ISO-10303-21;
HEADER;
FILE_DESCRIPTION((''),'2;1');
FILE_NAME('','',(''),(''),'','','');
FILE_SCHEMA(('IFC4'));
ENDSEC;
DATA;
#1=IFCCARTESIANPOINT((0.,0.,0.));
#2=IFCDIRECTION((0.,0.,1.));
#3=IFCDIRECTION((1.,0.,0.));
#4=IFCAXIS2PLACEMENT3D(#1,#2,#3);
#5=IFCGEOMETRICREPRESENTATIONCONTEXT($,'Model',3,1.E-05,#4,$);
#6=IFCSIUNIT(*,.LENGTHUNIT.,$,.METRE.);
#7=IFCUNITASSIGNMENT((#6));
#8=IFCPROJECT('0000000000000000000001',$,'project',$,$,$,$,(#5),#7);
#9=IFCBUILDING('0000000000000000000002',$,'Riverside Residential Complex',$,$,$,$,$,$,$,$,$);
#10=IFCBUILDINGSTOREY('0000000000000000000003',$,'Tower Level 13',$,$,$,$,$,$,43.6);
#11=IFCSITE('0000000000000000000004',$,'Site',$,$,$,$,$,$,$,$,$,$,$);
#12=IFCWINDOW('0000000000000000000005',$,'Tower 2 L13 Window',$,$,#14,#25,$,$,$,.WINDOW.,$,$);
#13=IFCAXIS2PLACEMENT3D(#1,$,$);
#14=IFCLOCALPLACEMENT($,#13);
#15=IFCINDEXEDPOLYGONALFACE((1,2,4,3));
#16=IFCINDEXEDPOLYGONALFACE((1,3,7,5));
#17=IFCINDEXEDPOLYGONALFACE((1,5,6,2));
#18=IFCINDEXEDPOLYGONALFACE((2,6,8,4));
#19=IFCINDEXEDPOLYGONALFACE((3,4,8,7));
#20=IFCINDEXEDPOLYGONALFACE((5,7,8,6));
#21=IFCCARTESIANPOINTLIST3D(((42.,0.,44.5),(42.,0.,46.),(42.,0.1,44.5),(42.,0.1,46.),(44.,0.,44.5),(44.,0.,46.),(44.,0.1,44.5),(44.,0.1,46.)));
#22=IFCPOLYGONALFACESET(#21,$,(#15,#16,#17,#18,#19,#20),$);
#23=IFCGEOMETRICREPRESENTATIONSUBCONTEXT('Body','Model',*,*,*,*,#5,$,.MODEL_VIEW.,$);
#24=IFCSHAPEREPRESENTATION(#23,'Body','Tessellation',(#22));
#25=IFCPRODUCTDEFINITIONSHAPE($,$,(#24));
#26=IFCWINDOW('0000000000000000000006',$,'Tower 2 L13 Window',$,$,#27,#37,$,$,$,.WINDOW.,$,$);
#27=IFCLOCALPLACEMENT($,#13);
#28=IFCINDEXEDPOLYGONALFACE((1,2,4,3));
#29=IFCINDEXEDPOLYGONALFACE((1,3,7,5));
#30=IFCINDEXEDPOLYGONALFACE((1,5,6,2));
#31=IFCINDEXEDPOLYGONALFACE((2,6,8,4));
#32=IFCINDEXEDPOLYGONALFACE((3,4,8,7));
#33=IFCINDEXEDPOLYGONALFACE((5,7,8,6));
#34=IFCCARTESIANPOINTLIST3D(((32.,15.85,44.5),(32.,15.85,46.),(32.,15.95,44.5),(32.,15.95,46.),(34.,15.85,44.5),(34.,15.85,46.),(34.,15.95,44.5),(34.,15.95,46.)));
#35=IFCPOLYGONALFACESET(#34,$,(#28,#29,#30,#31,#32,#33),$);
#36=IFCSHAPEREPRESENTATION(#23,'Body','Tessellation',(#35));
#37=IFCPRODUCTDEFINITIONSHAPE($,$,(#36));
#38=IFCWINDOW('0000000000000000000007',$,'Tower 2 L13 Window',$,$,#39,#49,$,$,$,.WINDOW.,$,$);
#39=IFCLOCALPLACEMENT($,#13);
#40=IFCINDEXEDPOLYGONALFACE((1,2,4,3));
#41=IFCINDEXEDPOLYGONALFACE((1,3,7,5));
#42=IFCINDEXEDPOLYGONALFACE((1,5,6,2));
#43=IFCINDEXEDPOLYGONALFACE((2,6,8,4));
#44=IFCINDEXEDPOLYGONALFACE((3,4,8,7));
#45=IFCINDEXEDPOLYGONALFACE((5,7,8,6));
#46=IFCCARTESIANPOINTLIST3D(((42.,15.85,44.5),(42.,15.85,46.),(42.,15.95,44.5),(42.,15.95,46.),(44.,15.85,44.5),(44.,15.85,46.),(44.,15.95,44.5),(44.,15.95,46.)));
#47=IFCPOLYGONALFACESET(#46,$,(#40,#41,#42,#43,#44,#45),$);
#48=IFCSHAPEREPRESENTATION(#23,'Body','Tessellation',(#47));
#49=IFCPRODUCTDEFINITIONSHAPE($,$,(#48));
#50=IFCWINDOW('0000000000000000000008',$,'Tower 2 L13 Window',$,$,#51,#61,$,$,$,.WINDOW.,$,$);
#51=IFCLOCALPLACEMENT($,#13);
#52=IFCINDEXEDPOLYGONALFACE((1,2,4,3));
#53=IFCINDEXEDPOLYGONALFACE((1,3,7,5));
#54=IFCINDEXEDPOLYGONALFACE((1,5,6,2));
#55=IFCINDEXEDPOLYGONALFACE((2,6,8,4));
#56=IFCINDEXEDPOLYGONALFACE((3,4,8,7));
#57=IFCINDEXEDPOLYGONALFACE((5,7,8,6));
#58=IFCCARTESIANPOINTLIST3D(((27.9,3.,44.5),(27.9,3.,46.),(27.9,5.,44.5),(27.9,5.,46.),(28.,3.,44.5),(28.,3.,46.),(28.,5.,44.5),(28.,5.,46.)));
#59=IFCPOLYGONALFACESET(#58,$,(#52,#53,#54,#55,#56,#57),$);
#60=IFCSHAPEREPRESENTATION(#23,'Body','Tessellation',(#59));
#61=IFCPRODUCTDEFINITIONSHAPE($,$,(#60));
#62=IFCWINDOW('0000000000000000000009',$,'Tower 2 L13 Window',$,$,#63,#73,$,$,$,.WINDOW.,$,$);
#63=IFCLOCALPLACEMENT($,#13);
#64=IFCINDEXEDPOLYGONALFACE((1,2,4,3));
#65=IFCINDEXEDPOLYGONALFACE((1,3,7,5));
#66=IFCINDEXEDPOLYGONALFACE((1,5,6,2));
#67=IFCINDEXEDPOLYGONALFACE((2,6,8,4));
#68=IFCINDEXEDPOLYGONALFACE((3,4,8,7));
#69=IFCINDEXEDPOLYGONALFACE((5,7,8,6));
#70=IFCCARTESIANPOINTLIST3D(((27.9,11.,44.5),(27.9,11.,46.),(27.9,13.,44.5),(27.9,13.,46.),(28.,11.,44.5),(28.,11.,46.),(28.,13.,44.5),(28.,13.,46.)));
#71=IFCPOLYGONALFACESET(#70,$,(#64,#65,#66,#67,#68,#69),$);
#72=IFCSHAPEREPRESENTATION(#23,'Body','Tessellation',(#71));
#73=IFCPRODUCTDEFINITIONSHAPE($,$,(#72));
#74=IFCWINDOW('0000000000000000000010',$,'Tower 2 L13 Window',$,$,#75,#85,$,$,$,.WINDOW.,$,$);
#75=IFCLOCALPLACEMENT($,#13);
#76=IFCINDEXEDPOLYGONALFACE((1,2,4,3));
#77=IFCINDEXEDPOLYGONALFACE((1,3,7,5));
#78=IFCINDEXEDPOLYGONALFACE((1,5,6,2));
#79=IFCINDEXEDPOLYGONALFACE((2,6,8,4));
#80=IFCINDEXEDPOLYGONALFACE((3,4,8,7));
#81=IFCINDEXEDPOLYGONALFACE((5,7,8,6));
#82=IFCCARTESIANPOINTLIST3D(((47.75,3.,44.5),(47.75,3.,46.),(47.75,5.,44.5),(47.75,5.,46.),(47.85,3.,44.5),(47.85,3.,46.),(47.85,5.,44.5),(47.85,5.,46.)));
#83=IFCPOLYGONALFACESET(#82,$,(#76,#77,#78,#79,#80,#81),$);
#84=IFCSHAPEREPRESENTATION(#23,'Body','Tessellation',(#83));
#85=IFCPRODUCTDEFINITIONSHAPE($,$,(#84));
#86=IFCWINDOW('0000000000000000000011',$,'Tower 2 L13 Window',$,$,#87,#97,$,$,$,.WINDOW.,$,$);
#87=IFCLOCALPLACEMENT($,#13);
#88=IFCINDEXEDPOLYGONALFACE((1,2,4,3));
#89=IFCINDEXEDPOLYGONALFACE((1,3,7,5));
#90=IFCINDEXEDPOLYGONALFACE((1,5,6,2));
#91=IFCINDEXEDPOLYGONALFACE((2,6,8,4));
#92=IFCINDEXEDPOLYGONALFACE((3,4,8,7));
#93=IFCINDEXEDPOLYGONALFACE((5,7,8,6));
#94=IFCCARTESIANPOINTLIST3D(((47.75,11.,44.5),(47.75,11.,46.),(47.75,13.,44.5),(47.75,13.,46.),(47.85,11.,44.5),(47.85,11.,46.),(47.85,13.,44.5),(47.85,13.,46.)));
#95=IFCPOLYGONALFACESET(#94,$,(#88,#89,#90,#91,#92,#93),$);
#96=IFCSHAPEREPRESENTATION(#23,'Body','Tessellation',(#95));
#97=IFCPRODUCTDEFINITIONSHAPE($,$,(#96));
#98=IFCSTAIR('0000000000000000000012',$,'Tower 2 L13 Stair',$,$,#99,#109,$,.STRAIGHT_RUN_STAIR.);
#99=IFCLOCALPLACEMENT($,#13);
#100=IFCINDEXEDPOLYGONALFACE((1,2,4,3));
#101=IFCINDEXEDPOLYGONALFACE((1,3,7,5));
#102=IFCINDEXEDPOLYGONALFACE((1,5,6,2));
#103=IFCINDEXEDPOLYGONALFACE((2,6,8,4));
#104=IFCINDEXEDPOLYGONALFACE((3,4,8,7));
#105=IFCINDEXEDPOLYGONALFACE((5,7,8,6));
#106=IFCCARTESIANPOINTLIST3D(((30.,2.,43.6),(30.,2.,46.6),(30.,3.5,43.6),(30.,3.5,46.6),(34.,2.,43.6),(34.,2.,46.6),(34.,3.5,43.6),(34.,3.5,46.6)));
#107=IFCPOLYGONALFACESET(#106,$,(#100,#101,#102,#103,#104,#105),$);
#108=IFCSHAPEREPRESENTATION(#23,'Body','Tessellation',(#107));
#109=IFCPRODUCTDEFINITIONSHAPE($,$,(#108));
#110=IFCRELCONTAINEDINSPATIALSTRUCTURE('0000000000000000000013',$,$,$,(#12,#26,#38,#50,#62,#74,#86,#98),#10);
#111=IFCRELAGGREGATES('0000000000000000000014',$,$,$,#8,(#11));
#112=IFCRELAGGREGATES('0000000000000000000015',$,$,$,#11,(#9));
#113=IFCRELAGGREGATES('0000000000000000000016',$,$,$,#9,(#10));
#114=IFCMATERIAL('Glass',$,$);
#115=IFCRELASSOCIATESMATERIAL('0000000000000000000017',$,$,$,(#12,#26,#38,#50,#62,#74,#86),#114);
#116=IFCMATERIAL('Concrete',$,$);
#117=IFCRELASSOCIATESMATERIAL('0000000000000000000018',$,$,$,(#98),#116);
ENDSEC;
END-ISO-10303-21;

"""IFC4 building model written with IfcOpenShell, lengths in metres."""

from ifc_helpers import new_model, si_unit, frame, origin_with_axes, place, context, subcontext, project, spatial, line, indexed_curve, outline, extrude, material, element, save


model = new_model("IFC4")

# Units and contexts
model_context = context("Model", 3, precision=1e-05, world=origin_with_axes())
body_context = subcontext(model_context, "Body", "Model", "MODEL_VIEW")
ifc_project = project(units=[si_unit("LENGTHUNIT", "METRE")], contexts=[model_context])

# Site, building, storey
site = spatial("IfcSite", under=ifc_project, Name="Site")
building = spatial("IfcBuilding", under=site, Name="Riverside Residential Complex")
storey = spatial("IfcBuildingStorey", under=building, Name="Tower Level 13", Elevation=43.6)

# Shared definitions
ifc_material_1 = material(Name="Concrete")

# Windows
ifc_material_2 = material(Name="Glass")
for number, where, z_axis, x_axis, name in (
    (1, (42.0, 0.0, 44.5), (0.0, 0.0, 1.0), (1.0, 0.0, 0.0), "Tower 2 L13 Window"),
    (2, (32.0, 15.85, 44.5), (0.0, 0.0, 1.0), (1.0, 0.0, 0.0), "Tower 2 L13 Window"),
    (3, (42.0, 15.85, 44.5), (0.0, 0.0, 1.0), (1.0, 0.0, 0.0), "Tower 2 L13 Window"),
    (4, (28.0, 3.0, 44.5), (0.0, 0.0, 1.0), (0.0, 1.0, 0.0), "Tower 2 L13 Window"),
    (5, (28.0, 11.0, 44.5), (0.0, 0.0, 1.0), (0.0, 1.0, 0.0), "Tower 2 L13 Window"),
    (6, (47.85, 3.0, 44.5), (0.0, 0.0, 1.0), (0.0, 1.0, 0.0), "Tower 2 L13 Window"),
    (7, (47.85, 11.0, 44.5), (0.0, 0.0, 1.0), (0.0, 1.0, 0.0), "Tower 2 L13 Window"),
):
    element("IfcWindow", number, at=place(None, frame(where, z_axis=z_axis, x_axis=x_axis)), inside=storey, material=ifc_material_2, Name=name, PredefinedType="WINDOW", context=body_context, shape_type="SweptSolid", body=[
        extrude(outline(indexed_curve([(0.0, 0.0), (2.0, 0.0), (2.0, 0.1), (0.0, 0.1)], segments=[line(1, 2, 3, 4, 1)])), origin_with_axes(), (0.0, 0.0, 1.0), 1.5),
    ])

# Stair
stair_placement = place(None, frame((30.0, 2.0, 43.6), z_axis=(0.0, 0.0, 1.0), x_axis=(1.0, 0.0, 0.0)))
element("IfcStair", 8, at=stair_placement, inside=storey, material=ifc_material_1, Name="Tower 2 L13 Stair", PredefinedType="STRAIGHT_RUN_STAIR", context=body_context, shape_type="SweptSolid", body=[
    extrude(outline(indexed_curve([(0.0, 0.0), (4.0, 0.0), (4.0, 1.5), (0.0, 1.5)], segments=[line(1, 2, 3, 4, 1)])), origin_with_axes(), (0.0, 0.0, 1.0), 3.0),
])

save(model, "model.ifc")
